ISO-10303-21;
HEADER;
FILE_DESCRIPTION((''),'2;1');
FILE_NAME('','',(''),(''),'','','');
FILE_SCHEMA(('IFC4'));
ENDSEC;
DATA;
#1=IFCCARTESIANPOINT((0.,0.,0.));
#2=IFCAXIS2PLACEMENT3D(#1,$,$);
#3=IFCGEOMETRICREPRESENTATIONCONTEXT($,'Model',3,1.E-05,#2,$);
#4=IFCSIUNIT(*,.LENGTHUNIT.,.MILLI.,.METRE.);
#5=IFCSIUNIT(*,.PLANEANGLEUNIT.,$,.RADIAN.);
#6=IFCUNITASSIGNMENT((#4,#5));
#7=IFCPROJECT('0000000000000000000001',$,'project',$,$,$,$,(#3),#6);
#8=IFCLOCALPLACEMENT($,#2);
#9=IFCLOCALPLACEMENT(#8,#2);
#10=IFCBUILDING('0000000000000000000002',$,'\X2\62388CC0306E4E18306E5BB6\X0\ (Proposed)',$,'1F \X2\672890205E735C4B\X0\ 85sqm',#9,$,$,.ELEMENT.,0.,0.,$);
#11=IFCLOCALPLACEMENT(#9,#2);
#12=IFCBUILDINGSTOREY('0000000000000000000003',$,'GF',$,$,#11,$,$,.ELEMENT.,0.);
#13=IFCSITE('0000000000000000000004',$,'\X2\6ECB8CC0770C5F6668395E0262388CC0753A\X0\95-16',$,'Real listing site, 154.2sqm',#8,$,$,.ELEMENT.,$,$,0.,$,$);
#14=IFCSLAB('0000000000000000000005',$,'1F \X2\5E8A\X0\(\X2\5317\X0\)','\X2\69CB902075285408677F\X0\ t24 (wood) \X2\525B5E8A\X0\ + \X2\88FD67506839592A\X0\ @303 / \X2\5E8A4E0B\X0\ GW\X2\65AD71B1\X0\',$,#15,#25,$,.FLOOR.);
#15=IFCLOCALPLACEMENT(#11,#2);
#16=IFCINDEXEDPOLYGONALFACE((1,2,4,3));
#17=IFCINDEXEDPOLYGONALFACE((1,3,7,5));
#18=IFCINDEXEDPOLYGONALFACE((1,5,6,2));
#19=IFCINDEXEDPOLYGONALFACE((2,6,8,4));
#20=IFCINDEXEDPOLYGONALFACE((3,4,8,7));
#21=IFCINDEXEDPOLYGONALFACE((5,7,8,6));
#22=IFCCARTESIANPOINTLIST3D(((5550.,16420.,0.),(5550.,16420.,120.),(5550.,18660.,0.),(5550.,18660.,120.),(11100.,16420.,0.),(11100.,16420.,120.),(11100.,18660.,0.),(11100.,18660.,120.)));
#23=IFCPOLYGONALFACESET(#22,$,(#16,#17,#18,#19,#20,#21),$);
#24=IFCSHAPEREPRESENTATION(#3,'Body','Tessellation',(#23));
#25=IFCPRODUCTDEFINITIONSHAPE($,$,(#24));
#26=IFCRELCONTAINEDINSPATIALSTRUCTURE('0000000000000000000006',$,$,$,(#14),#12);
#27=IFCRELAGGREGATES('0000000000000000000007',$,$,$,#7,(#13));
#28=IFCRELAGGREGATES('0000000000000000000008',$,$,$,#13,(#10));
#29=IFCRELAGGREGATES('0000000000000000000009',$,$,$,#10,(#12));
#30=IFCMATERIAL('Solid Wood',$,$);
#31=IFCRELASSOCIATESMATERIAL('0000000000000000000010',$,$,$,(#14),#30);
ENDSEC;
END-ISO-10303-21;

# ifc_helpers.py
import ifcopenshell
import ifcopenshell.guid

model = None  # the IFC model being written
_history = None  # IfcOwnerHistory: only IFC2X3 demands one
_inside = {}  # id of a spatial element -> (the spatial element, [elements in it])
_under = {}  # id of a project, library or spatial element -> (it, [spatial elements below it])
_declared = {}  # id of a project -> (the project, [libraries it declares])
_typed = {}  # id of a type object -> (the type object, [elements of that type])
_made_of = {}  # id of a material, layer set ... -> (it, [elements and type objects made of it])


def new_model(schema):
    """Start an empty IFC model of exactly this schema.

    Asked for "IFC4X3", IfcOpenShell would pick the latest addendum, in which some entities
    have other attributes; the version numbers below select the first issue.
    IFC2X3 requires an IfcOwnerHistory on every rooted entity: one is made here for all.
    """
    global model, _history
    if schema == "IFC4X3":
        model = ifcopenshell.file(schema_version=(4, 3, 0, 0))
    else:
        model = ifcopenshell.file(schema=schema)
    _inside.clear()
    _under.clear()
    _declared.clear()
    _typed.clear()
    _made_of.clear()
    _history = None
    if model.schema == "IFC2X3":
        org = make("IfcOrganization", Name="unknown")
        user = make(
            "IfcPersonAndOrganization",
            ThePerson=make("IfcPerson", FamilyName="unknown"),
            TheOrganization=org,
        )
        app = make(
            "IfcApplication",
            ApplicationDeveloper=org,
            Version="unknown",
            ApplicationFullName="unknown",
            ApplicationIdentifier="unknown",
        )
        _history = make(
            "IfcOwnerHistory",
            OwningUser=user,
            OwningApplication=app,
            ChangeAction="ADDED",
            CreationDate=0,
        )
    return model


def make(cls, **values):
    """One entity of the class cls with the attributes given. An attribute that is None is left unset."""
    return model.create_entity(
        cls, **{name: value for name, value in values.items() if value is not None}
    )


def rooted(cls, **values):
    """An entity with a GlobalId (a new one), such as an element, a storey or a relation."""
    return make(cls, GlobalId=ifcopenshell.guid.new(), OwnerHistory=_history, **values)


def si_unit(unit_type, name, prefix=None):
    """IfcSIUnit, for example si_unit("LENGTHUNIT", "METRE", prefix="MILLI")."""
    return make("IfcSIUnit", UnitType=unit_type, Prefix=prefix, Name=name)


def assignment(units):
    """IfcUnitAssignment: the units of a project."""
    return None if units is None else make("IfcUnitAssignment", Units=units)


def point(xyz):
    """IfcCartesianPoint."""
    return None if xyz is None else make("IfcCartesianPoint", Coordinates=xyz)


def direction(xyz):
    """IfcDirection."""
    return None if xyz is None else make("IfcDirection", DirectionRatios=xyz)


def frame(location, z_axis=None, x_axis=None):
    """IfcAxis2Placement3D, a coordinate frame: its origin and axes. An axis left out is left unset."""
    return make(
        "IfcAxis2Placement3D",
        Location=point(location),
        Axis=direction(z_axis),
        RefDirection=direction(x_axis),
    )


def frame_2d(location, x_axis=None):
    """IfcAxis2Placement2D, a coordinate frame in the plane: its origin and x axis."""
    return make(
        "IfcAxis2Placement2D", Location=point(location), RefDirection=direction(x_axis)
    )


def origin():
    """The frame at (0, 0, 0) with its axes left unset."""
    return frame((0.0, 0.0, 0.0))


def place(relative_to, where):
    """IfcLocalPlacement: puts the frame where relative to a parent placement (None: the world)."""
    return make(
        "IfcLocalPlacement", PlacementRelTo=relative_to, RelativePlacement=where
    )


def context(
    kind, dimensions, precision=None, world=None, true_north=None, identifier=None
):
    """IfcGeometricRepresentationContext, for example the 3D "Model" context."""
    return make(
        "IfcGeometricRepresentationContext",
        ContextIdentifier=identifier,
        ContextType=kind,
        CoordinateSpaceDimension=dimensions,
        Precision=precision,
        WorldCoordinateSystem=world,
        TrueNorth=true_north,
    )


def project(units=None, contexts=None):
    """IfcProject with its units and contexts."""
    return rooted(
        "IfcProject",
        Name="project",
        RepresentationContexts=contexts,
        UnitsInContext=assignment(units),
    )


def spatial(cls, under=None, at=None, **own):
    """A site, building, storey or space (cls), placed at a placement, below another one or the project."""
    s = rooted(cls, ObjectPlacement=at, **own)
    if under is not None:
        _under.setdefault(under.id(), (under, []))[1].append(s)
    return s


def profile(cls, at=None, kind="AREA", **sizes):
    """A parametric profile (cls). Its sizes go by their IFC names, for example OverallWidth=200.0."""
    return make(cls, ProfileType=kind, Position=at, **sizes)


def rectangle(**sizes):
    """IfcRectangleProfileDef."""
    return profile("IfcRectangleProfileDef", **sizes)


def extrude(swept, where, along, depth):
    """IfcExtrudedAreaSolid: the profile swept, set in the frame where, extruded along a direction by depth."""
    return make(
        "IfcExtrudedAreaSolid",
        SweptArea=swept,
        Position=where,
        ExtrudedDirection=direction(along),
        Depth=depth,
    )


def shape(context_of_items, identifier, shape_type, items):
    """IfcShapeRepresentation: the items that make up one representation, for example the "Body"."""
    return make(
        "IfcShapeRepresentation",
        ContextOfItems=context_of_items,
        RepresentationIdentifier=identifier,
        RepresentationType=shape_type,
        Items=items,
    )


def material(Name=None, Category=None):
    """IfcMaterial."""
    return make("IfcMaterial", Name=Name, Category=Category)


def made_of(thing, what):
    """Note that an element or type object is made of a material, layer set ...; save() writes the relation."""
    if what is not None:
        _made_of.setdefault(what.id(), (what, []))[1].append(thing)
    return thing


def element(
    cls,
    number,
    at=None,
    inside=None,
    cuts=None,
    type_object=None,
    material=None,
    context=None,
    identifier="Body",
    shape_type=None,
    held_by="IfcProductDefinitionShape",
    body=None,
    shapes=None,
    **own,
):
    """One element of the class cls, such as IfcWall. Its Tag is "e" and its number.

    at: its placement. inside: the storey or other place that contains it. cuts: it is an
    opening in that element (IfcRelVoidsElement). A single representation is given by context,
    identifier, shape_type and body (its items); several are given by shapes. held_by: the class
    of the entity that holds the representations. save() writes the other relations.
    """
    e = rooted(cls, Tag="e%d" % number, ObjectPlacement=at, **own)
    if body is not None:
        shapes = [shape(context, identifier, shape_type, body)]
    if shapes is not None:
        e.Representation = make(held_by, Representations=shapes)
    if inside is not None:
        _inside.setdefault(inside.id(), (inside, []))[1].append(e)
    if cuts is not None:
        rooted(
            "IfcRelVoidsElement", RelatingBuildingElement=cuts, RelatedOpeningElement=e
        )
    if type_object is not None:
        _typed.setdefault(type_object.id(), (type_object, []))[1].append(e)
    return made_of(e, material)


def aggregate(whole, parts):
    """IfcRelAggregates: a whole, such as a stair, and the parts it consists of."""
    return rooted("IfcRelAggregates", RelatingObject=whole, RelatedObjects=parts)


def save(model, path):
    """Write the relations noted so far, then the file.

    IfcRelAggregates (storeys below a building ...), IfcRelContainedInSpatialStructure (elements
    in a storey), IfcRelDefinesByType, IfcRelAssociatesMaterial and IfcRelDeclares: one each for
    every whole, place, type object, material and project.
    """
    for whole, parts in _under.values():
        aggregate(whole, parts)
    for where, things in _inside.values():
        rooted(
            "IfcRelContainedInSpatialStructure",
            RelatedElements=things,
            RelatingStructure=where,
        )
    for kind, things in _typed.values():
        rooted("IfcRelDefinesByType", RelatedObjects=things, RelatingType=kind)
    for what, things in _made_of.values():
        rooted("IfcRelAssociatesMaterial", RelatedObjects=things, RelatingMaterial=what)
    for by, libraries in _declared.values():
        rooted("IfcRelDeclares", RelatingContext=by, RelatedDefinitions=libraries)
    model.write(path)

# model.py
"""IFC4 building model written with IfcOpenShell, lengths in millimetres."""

from ifc_helpers import new_model, si_unit, frame, frame_2d, origin, place, context, project, spatial, rectangle, extrude, material, element, save


model = new_model("IFC4")

# Units and contexts
model_context = context("Model", 3, precision=1e-05, world=origin())
ifc_project = project(units=[si_unit("LENGTHUNIT", "METRE", prefix="MILLI"), si_unit("PLANEANGLEUNIT", "RADIAN")], contexts=[model_context])

# Site, building, storey
site_placement = place(None, origin())
site = spatial("IfcSite", under=ifc_project, at=site_placement, Name="滋賀県彦根市戸賀町95-16", ObjectType="Real listing site, 154.2sqm", CompositionType="ELEMENT", RefElevation=0.0)
building_placement = place(site_placement, origin())
building = spatial("IfcBuilding", under=site, at=building_placement, Name="戸賀の丘の家 (Proposed)", ObjectType="1F 木造平屋 85sqm", CompositionType="ELEMENT", ElevationOfRefHeight=0.0, ElevationOfTerrain=0.0)
storey_placement = place(building_placement, origin())
storey = spatial("IfcBuildingStorey", under=building, at=storey_placement, Name="GF", CompositionType="ELEMENT", Elevation=0.0)

# Slab
ifc_material_1 = material(Name="Solid Wood")
slab_1_placement = place(storey_placement, frame((2775.0, 8210.0, 0.0)))
element("IfcSlab", 1, at=slab_1_placement, inside=storey, material=ifc_material_1, Name="1F 床(北)", Description="構造用合板 t24 (wood) 剛床 + 製材根太 @303 / 床下 GW断熱", PredefinedType="FLOOR", context=model_context, shape_type="SweptSolid", body=[
    extrude(rectangle(XDim=5550.0, YDim=2240.0, at=frame_2d((2775.0, 1120.0))), frame((2775.0, 8210.0, 0.0)), (0.0, 0.0, 1.0), 120.0),
])

save(model, "model.ifc")
